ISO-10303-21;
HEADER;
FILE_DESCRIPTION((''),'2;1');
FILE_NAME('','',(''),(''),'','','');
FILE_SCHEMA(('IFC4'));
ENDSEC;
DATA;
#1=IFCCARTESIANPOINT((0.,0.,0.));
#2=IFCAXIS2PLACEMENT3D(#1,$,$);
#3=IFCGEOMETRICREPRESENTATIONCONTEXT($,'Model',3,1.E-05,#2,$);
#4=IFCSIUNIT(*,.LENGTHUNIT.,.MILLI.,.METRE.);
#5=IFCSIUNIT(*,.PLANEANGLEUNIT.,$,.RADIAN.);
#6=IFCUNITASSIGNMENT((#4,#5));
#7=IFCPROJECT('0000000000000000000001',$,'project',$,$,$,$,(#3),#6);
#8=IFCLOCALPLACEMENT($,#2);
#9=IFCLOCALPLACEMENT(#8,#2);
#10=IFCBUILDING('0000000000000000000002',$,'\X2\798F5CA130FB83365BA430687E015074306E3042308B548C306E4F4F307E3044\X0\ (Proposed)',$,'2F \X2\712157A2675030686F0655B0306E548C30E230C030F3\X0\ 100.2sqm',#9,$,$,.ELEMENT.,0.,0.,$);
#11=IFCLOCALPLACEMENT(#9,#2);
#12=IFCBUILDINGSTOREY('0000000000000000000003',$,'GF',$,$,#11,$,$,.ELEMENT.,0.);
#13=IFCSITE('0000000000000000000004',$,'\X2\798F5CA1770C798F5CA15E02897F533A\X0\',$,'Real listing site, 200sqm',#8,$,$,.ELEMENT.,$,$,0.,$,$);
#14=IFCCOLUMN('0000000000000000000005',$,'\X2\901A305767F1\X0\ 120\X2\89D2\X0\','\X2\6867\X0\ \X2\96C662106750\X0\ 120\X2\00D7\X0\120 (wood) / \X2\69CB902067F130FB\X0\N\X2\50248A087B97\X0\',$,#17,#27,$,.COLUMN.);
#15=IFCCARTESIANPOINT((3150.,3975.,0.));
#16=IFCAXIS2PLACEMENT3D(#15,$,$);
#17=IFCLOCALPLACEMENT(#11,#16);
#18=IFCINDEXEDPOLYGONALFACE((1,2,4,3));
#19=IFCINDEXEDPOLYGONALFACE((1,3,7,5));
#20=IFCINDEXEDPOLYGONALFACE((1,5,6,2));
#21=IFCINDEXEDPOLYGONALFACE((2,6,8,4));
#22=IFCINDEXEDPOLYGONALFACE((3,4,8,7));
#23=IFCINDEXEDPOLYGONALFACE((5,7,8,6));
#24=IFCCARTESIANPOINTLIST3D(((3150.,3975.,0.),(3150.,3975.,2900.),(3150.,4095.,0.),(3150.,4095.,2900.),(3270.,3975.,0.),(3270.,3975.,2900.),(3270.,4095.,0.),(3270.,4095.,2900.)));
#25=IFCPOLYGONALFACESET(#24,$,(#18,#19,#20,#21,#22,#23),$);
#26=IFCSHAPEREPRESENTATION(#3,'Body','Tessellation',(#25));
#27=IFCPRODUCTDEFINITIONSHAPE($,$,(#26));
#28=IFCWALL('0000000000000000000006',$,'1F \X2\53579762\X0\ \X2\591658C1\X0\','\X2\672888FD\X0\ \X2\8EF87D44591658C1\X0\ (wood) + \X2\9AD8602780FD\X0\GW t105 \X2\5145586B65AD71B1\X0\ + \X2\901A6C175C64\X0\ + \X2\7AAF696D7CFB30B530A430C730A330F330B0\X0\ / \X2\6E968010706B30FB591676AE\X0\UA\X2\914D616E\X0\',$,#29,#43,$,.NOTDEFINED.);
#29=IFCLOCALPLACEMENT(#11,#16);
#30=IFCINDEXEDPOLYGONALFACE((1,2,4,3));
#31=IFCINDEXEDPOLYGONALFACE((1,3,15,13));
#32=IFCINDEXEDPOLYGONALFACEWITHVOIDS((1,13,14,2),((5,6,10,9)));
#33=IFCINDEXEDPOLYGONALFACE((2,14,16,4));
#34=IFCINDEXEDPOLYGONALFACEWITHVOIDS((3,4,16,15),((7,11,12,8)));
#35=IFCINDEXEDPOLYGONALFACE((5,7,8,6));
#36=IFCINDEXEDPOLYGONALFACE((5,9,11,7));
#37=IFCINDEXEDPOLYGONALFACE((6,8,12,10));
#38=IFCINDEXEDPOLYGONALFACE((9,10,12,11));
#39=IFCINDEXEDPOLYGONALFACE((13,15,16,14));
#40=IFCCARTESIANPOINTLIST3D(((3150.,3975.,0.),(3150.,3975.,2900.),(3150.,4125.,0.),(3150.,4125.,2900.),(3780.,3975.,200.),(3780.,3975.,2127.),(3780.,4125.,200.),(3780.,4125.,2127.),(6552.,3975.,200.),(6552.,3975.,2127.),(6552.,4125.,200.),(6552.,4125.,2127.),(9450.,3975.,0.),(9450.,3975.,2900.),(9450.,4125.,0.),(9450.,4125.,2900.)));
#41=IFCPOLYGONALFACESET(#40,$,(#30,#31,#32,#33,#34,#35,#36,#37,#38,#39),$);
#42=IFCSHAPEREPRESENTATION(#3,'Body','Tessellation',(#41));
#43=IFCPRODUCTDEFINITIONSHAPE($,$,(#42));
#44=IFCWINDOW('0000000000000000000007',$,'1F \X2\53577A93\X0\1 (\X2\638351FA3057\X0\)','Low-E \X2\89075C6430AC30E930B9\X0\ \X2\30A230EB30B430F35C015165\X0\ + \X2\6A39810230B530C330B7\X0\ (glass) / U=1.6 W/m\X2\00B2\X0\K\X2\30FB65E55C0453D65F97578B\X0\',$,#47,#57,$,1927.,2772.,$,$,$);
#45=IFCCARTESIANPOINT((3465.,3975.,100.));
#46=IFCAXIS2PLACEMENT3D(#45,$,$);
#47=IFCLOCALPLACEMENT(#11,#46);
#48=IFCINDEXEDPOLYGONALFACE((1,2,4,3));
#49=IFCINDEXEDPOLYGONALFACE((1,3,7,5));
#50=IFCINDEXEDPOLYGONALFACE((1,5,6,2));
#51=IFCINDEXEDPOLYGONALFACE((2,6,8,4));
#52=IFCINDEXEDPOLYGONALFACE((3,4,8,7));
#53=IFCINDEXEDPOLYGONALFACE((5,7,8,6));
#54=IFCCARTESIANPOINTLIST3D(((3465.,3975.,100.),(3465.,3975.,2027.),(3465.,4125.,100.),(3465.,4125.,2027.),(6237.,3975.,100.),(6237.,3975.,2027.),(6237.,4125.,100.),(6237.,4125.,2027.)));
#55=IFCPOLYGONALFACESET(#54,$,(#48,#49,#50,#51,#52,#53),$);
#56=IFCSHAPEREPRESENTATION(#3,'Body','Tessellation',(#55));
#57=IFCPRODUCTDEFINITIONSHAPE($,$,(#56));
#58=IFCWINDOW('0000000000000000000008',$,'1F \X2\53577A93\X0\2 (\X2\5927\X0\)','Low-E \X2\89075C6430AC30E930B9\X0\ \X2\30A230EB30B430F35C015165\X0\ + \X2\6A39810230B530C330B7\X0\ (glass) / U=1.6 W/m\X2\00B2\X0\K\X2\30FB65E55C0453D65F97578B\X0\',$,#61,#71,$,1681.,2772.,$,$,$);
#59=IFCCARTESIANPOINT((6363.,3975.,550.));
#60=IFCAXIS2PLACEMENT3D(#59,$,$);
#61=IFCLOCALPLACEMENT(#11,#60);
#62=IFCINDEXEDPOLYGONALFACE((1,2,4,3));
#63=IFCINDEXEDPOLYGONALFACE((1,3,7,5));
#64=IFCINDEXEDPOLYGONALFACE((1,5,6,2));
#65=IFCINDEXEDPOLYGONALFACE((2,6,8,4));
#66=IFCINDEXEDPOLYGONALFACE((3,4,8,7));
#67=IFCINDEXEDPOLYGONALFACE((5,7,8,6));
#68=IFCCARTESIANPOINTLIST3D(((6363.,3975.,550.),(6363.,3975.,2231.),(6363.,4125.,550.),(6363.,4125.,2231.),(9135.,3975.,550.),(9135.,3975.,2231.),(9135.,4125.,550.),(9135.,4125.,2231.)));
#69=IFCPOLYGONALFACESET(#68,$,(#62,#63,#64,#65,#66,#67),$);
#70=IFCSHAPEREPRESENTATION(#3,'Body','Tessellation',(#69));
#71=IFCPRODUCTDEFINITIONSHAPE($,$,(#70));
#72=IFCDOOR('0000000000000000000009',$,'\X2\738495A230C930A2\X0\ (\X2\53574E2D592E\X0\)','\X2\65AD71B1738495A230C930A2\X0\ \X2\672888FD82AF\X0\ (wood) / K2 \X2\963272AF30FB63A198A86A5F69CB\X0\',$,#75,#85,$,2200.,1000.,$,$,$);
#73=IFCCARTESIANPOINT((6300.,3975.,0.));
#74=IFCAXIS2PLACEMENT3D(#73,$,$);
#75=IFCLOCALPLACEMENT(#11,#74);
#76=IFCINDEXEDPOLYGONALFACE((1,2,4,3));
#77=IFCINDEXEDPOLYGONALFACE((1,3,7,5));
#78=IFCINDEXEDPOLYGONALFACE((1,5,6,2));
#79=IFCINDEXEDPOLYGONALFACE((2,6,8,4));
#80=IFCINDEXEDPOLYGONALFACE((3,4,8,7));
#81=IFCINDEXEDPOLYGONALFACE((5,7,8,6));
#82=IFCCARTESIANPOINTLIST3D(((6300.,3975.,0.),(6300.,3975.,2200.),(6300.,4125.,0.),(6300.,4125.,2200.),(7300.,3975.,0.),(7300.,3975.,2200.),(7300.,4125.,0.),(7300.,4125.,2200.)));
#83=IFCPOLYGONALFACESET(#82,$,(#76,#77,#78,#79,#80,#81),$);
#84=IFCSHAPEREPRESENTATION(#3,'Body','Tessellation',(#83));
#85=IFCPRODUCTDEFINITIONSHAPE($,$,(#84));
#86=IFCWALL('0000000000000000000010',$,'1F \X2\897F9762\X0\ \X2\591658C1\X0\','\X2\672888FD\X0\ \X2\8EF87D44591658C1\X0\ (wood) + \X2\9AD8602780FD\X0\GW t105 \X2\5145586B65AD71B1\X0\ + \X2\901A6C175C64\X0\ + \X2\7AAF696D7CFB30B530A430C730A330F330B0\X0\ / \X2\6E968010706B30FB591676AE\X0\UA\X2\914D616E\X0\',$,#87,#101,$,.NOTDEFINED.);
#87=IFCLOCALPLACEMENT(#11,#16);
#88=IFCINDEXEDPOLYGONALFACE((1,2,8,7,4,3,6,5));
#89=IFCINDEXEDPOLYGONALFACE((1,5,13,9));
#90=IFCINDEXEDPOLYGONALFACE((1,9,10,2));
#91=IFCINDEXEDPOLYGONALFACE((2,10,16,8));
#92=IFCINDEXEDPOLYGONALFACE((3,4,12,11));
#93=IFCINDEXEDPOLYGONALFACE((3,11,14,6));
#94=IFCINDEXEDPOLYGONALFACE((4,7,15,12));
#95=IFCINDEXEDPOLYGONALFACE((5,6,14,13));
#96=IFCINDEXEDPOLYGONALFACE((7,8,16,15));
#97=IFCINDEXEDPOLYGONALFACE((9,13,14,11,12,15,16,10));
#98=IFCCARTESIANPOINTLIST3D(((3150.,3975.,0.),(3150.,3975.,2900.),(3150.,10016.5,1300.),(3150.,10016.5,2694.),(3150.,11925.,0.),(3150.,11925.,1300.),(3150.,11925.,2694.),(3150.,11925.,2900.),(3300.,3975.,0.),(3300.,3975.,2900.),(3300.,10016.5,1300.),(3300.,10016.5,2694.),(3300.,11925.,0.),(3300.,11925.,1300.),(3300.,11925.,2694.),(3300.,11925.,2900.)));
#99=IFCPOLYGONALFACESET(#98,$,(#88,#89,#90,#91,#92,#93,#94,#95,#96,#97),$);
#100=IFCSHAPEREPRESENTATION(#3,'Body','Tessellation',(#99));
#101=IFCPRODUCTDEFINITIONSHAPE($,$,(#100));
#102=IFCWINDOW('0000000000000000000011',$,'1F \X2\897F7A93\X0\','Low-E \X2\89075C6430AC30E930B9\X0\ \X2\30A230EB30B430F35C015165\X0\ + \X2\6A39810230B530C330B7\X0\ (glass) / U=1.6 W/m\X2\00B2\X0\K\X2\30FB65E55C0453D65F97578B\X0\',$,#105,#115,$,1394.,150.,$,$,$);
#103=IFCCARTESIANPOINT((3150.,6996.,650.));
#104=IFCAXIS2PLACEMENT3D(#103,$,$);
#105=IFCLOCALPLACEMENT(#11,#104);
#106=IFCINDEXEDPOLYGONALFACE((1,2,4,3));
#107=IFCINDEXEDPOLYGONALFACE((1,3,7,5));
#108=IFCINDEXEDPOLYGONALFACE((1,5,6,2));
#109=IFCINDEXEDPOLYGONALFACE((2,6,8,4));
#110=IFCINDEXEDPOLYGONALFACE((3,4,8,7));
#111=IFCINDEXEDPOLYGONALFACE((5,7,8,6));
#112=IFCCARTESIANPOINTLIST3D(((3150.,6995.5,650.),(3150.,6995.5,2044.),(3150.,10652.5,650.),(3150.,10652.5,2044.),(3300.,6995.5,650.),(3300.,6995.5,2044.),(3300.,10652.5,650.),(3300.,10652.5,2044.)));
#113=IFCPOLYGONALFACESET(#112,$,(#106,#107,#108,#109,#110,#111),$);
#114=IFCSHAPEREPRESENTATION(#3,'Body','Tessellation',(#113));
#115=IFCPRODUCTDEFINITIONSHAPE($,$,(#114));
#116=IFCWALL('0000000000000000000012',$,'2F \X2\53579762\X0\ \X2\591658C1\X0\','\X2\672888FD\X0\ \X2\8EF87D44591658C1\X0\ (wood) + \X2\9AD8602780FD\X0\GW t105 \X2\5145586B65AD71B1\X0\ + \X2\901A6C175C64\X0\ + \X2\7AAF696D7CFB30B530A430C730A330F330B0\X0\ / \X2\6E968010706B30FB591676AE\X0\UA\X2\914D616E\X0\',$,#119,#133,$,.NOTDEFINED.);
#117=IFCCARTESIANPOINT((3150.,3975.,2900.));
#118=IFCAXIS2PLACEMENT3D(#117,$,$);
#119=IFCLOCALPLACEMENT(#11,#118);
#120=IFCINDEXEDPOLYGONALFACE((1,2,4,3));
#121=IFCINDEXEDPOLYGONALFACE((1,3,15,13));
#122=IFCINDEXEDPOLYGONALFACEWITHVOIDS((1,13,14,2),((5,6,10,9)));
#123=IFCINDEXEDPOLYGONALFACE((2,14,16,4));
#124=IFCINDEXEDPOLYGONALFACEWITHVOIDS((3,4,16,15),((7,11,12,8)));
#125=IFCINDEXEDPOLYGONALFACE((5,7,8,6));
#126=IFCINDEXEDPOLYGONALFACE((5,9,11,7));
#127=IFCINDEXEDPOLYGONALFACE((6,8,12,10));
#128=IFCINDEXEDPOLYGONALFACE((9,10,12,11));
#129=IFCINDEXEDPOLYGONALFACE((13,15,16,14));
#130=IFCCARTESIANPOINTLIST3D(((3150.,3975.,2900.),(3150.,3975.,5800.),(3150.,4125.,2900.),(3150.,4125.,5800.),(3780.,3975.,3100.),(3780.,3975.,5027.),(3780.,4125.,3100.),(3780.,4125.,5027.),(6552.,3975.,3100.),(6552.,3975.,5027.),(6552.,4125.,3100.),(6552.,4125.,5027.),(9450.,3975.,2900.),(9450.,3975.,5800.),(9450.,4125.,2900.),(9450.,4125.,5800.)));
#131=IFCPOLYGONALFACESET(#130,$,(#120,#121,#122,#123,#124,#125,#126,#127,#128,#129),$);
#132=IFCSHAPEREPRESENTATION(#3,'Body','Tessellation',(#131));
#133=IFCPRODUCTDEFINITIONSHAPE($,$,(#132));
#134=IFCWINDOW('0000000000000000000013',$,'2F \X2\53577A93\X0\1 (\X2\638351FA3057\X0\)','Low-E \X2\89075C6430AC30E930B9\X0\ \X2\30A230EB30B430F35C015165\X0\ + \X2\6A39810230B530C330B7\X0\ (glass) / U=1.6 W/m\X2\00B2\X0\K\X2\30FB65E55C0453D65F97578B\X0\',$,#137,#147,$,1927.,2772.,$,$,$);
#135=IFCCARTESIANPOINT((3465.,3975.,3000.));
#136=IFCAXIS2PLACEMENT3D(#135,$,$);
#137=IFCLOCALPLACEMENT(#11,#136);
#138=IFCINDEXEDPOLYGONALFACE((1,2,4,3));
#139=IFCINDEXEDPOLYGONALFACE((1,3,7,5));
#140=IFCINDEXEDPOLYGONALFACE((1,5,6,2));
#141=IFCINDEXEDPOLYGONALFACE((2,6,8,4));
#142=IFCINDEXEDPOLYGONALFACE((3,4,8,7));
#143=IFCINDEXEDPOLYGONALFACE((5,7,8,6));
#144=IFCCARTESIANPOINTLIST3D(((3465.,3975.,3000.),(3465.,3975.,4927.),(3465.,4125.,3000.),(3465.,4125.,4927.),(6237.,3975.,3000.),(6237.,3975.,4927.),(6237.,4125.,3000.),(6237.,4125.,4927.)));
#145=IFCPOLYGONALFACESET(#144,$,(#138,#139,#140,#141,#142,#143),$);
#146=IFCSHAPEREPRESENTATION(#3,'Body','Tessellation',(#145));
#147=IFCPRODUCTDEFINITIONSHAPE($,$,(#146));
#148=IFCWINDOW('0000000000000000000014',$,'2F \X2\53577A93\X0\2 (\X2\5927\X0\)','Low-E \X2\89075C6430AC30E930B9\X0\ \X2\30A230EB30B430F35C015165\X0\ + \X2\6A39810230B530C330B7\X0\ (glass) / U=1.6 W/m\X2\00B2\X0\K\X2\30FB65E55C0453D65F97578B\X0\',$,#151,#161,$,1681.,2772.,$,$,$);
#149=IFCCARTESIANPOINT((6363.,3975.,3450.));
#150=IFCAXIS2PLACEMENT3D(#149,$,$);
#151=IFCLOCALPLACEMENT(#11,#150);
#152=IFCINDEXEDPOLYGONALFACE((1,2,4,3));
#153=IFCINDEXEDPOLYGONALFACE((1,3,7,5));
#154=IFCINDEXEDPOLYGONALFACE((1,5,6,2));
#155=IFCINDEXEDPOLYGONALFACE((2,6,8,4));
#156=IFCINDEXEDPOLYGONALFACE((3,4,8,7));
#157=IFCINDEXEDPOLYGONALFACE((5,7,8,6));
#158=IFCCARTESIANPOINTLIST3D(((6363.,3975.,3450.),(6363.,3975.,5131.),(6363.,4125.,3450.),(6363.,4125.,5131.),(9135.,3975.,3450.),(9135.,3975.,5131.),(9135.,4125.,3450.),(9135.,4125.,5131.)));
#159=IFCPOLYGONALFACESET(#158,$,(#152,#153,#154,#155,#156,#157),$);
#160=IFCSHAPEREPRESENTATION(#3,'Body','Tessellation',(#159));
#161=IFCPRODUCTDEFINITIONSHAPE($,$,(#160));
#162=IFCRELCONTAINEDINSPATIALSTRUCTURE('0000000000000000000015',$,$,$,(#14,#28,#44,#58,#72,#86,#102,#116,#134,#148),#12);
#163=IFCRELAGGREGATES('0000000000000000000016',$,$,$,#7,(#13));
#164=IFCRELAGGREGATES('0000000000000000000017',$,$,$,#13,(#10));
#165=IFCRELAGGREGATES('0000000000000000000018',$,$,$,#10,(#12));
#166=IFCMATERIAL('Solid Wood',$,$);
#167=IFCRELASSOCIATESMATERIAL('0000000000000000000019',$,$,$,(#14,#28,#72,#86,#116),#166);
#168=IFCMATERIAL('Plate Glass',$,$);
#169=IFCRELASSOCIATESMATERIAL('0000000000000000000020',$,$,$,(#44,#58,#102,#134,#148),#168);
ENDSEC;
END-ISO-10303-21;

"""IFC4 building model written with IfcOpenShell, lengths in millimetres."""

from ifc_helpers import new_model, si_unit, frame, frame_2d, origin, place, context, project, spatial, rectangle, extrude, material, element, fill, save


model = new_model("IFC4")

# Units and contexts
model_context = context("Model", 3, precision=1e-05, world=origin())
ifc_project = project(units=[si_unit("LENGTHUNIT", "METRE", prefix="MILLI"), si_unit("PLANEANGLEUNIT", "RADIAN")], contexts=[model_context])

# Site, building, storey
site_placement = place(None, origin())
site = spatial("IfcSite", under=ifc_project, at=site_placement, Name="福岡県福岡市西区", ObjectType="Real listing site, 200sqm", CompositionType="ELEMENT", RefElevation=0.0)
building_placement = place(site_placement, origin())
building = spatial("IfcBuilding", under=site, at=building_placement, Name="福岡・茶室と縁側のある和の住まい (Proposed)", ObjectType="2F 無垢材と漆喰の和モダン 100.2sqm", CompositionType="ELEMENT", ElevationOfRefHeight=0.0, ElevationOfTerrain=0.0)
storey_placement = place(building_placement, origin())
storey = spatial("IfcBuildingStorey", under=building, at=storey_placement, Name="GF", CompositionType="ELEMENT", Elevation=0.0)

# Column
ifc_material_1 = material(Name="Solid Wood")
column_placement = place(storey_placement, frame((3150.0, 3975.0, 0.0)))
element("IfcColumn", 1, at=column_placement, inside=storey, material=ifc_material_1, Name="通し柱 120角", Description="桧 集成材 120×120 (wood) / 構造柱・N値計算", PredefinedType="COLUMN", context=model_context, shape_type="SweptSolid", body=[
    extrude(rectangle(XDim=120.0, YDim=120.0, at=frame_2d((60.0, 60.0))), frame((3150.0, 3975.0, 0.0)), (0.0, 0.0, 1.0), 2900.0),
])

# Wall, openings, windows, door
wall_1_placement = place(storey_placement, frame((3150.0, 3975.0, 0.0)))
wall_1 = element("IfcWall", 2, at=wall_1_placement, inside=storey, material=ifc_material_1, Name="1F 南面 外壁", Description="木製 軸組外壁 (wood) + 高性能GW t105 充填断熱 + 通気層 + 窯業系サイディング / 準耐火・外皮UA配慮", PredefinedType="NOTDEFINED", context=model_context, shape_type="SweptSolid", body=[
    extrude(rectangle(XDim=6300.0, YDim=150.0, at=frame_2d((3150.0, 75.0))), frame((3150.0, 3975.0, 0.0)), (0.0, 0.0, 1.0), 2900.0),
])
opening_1_placement = place(storey_placement, frame((3465.0, 3975.0, 100.0)))
opening_1 = element("IfcOpeningElement", 3, at=opening_1_placement, cuts=wall_1, PredefinedType="NOTDEFINED", context=model_context, shape_type="SweptSolid", body=[
    extrude(rectangle(XDim=2772.0, YDim=150.0, at=frame_2d((1386.0, 75.0))), frame((3465.0, 3975.0, 100.0)), (0.0, 0.0, 1.0), 1927.0),
])
opening_2_placement = place(storey_placement, frame((6363.0, 3975.0, 550.0)))
opening_2 = element("IfcOpeningElement", 4, at=opening_2_placement, cuts=wall_1, PredefinedType="NOTDEFINED", context=model_context, shape_type="SweptSolid", body=[
    extrude(rectangle(XDim=2772.0, YDim=150.0, at=frame_2d((1386.0, 75.0))), frame((6363.0, 3975.0, 550.0)), (0.0, 0.0, 1.0), 1681.0),
])
opening_3_placement = place(storey_placement, frame((6300.0, 3975.0, 0.0)))
opening_3 = element("IfcOpeningElement", 5, at=opening_3_placement, cuts=wall_1, PredefinedType="NOTDEFINED", context=model_context, shape_type="SweptSolid", body=[
    extrude(rectangle(XDim=1000.0, YDim=150.0, at=frame_2d((500.0, 75.0))), frame((6300.0, 3975.0, 0.0)), (0.0, 0.0, 1.0), 2200.0),
])
ifc_material_2 = material(Name="Plate Glass")
window_1_placement = place(storey_placement, frame((3465.0, 3975.0, 100.0)))
window_1 = element("IfcWindow", 6, at=window_1_placement, inside=storey, material=ifc_material_2, Name="1F 南窓1 (掃出し)", Description="Low-E 複層ガラス アルゴン封入 + 樹脂サッシ (glass) / U=1.6 W/m²K・日射取得型", OverallHeight=1927.0, OverallWidth=2772.0, context=model_context, shape_type="SweptSolid", body=[
    extrude(rectangle(XDim=2772.0, YDim=150.0, at=frame_2d((1386.0, 75.0))), frame((3465.0, 3975.0, 100.0)), (0.0, 0.0, 1.0), 1927.0),
])
fill(opening_1, window_1)
window_2_placement = place(storey_placement, frame((6363.0, 3975.0, 550.0)))
window_2 = element("IfcWindow", 7, at=window_2_placement, inside=storey, material=ifc_material_2, Name="1F 南窓2 (大)", Description="Low-E 複層ガラス アルゴン封入 + 樹脂サッシ (glass) / U=1.6 W/m²K・日射取得型", OverallHeight=1681.0, OverallWidth=2772.0, context=model_context, shape_type="SweptSolid", body=[
    extrude(rectangle(XDim=2772.0, YDim=150.0, at=frame_2d((1386.0, 75.0))), frame((6363.0, 3975.0, 550.0)), (0.0, 0.0, 1.0), 1681.0),
])
fill(opening_2, window_2)
door_placement = place(storey_placement, frame((6300.0, 3975.0, 0.0)))
door = element("IfcDoor", 8, at=door_placement, inside=storey, material=ifc_material_1, Name="玄関ドア (南中央)", Description="断熱玄関ドア 木製芯 (wood) / K2 防犯・採風機構", OverallHeight=2200.0, OverallWidth=1000.0, context=model_context, shape_type="SweptSolid", body=[
    extrude(rectangle(XDim=1000.0, YDim=150.0, at=frame_2d((500.0, 75.0))), frame((6300.0, 3975.0, 0.0)), (0.0, 0.0, 1.0), 2200.0),
])
fill(opening_3, door)

# Wall, opening, window
wall_2_placement = place(storey_placement, frame((3150.0, 3975.0, 0.0)))
wall_2 = element("IfcWall", 9, at=wall_2_placement, inside=storey, material=ifc_material_1, Name="1F 西面 外壁", Description="木製 軸組外壁 (wood) + 高性能GW t105 充填断熱 + 通気層 + 窯業系サイディング / 準耐火・外皮UA配慮", PredefinedType="NOTDEFINED", context=model_context, shape_type="SweptSolid", body=[
    extrude(rectangle(XDim=150.0, YDim=7950.0, at=frame_2d((75.0, 3975.0))), frame((3150.0, 3975.0, 0.0)), (0.0, 0.0, 1.0), 2900.0),
])
opening_4_placement = place(storey_placement, frame((3150.0, 6996.0, 650.0)))
opening_4 = element("IfcOpeningElement", 10, at=opening_4_placement, cuts=wall_2, PredefinedType="NOTDEFINED", context=model_context, shape_type="SweptSolid", body=[
    extrude(rectangle(XDim=150.0, YDim=3657.0, at=frame_2d((75.0, 1828.0))), frame((3150.0, 6996.0, 650.0)), (0.0, 0.0, 1.0), 1394.0),
])
window_3_placement = place(storey_placement, frame((3150.0, 6996.0, 650.0)))
window_3 = element("IfcWindow", 11, at=window_3_placement, inside=storey, material=ifc_material_2, Name="1F 西窓", Description="Low-E 複層ガラス アルゴン封入 + 樹脂サッシ (glass) / U=1.6 W/m²K・日射取得型", OverallHeight=1394.0, OverallWidth=150.0, context=model_context, shape_type="SweptSolid", body=[
    extrude(rectangle(XDim=150.0, YDim=3657.0, at=frame_2d((75.0, 1828.0))), frame((3150.0, 6996.0, 650.0)), (0.0, 0.0, 1.0), 1394.0),
])
fill(opening_4, window_3)

# Wall, openings, windows
wall_3_placement = place(storey_placement, frame((3150.0, 3975.0, 2900.0)))
wall_3 = element("IfcWall", 12, at=wall_3_placement, inside=storey, material=ifc_material_1, Name="2F 南面 外壁", Description="木製 軸組外壁 (wood) + 高性能GW t105 充填断熱 + 通気層 + 窯業系サイディング / 準耐火・外皮UA配慮", PredefinedType="NOTDEFINED", context=model_context, shape_type="SweptSolid", body=[
    extrude(rectangle(XDim=6300.0, YDim=150.0, at=frame_2d((3150.0, 75.0))), frame((3150.0, 3975.0, 2900.0)), (0.0, 0.0, 1.0), 2900.0),
])
opening_5_placement = place(storey_placement, frame((3465.0, 3975.0, 3000.0)))
opening_5 = element("IfcOpeningElement", 13, at=opening_5_placement, cuts=wall_3, PredefinedType="NOTDEFINED", context=model_context, shape_type="SweptSolid", body=[
    extrude(rectangle(XDim=2772.0, YDim=150.0, at=frame_2d((1386.0, 75.0))), frame((3465.0, 3975.0, 3000.0)), (0.0, 0.0, 1.0), 1927.0),
])
opening_6_placement = place(storey_placement, frame((6363.0, 3975.0, 3450.0)))
opening_6 = element("IfcOpeningElement", 14, at=opening_6_placement, cuts=wall_3, PredefinedType="NOTDEFINED", context=model_context, shape_type="SweptSolid", body=[
    extrude(rectangle(XDim=2772.0, YDim=150.0, at=frame_2d((1386.0, 75.0))), frame((6363.0, 3975.0, 3450.0)), (0.0, 0.0, 1.0), 1681.0),
])
window_4_placement = place(storey_placement, frame((3465.0, 3975.0, 3000.0)))
window_4 = element("IfcWindow", 15, at=window_4_placement, inside=storey, material=ifc_material_2, Name="2F 南窓1 (掃出し)", Description="Low-E 複層ガラス アルゴン封入 + 樹脂サッシ (glass) / U=1.6 W/m²K・日射取得型", OverallHeight=1927.0, OverallWidth=2772.0, context=model_context, shape_type="SweptSolid", body=[
    extrude(rectangle(XDim=2772.0, YDim=150.0, at=frame_2d((1386.0, 75.0))), frame((3465.0, 3975.0, 3000.0)), (0.0, 0.0, 1.0), 1927.0),
])
fill(opening_5, window_4)
window_5_placement = place(storey_placement, frame((6363.0, 3975.0, 3450.0)))
window_5 = element("IfcWindow", 16, at=window_5_placement, inside=storey, material=ifc_material_2, Name="2F 南窓2 (大)", Description="Low-E 複層ガラス アルゴン封入 + 樹脂サッシ (glass) / U=1.6 W/m²K・日射取得型", OverallHeight=1681.0, OverallWidth=2772.0, context=model_context, shape_type="SweptSolid", body=[
    extrude(rectangle(XDim=2772.0, YDim=150.0, at=frame_2d((1386.0, 75.0))), frame((6363.0, 3975.0, 3450.0)), (0.0, 0.0, 1.0), 1681.0),
])
fill(opening_6, window_5)

save(model, "model.ifc")
